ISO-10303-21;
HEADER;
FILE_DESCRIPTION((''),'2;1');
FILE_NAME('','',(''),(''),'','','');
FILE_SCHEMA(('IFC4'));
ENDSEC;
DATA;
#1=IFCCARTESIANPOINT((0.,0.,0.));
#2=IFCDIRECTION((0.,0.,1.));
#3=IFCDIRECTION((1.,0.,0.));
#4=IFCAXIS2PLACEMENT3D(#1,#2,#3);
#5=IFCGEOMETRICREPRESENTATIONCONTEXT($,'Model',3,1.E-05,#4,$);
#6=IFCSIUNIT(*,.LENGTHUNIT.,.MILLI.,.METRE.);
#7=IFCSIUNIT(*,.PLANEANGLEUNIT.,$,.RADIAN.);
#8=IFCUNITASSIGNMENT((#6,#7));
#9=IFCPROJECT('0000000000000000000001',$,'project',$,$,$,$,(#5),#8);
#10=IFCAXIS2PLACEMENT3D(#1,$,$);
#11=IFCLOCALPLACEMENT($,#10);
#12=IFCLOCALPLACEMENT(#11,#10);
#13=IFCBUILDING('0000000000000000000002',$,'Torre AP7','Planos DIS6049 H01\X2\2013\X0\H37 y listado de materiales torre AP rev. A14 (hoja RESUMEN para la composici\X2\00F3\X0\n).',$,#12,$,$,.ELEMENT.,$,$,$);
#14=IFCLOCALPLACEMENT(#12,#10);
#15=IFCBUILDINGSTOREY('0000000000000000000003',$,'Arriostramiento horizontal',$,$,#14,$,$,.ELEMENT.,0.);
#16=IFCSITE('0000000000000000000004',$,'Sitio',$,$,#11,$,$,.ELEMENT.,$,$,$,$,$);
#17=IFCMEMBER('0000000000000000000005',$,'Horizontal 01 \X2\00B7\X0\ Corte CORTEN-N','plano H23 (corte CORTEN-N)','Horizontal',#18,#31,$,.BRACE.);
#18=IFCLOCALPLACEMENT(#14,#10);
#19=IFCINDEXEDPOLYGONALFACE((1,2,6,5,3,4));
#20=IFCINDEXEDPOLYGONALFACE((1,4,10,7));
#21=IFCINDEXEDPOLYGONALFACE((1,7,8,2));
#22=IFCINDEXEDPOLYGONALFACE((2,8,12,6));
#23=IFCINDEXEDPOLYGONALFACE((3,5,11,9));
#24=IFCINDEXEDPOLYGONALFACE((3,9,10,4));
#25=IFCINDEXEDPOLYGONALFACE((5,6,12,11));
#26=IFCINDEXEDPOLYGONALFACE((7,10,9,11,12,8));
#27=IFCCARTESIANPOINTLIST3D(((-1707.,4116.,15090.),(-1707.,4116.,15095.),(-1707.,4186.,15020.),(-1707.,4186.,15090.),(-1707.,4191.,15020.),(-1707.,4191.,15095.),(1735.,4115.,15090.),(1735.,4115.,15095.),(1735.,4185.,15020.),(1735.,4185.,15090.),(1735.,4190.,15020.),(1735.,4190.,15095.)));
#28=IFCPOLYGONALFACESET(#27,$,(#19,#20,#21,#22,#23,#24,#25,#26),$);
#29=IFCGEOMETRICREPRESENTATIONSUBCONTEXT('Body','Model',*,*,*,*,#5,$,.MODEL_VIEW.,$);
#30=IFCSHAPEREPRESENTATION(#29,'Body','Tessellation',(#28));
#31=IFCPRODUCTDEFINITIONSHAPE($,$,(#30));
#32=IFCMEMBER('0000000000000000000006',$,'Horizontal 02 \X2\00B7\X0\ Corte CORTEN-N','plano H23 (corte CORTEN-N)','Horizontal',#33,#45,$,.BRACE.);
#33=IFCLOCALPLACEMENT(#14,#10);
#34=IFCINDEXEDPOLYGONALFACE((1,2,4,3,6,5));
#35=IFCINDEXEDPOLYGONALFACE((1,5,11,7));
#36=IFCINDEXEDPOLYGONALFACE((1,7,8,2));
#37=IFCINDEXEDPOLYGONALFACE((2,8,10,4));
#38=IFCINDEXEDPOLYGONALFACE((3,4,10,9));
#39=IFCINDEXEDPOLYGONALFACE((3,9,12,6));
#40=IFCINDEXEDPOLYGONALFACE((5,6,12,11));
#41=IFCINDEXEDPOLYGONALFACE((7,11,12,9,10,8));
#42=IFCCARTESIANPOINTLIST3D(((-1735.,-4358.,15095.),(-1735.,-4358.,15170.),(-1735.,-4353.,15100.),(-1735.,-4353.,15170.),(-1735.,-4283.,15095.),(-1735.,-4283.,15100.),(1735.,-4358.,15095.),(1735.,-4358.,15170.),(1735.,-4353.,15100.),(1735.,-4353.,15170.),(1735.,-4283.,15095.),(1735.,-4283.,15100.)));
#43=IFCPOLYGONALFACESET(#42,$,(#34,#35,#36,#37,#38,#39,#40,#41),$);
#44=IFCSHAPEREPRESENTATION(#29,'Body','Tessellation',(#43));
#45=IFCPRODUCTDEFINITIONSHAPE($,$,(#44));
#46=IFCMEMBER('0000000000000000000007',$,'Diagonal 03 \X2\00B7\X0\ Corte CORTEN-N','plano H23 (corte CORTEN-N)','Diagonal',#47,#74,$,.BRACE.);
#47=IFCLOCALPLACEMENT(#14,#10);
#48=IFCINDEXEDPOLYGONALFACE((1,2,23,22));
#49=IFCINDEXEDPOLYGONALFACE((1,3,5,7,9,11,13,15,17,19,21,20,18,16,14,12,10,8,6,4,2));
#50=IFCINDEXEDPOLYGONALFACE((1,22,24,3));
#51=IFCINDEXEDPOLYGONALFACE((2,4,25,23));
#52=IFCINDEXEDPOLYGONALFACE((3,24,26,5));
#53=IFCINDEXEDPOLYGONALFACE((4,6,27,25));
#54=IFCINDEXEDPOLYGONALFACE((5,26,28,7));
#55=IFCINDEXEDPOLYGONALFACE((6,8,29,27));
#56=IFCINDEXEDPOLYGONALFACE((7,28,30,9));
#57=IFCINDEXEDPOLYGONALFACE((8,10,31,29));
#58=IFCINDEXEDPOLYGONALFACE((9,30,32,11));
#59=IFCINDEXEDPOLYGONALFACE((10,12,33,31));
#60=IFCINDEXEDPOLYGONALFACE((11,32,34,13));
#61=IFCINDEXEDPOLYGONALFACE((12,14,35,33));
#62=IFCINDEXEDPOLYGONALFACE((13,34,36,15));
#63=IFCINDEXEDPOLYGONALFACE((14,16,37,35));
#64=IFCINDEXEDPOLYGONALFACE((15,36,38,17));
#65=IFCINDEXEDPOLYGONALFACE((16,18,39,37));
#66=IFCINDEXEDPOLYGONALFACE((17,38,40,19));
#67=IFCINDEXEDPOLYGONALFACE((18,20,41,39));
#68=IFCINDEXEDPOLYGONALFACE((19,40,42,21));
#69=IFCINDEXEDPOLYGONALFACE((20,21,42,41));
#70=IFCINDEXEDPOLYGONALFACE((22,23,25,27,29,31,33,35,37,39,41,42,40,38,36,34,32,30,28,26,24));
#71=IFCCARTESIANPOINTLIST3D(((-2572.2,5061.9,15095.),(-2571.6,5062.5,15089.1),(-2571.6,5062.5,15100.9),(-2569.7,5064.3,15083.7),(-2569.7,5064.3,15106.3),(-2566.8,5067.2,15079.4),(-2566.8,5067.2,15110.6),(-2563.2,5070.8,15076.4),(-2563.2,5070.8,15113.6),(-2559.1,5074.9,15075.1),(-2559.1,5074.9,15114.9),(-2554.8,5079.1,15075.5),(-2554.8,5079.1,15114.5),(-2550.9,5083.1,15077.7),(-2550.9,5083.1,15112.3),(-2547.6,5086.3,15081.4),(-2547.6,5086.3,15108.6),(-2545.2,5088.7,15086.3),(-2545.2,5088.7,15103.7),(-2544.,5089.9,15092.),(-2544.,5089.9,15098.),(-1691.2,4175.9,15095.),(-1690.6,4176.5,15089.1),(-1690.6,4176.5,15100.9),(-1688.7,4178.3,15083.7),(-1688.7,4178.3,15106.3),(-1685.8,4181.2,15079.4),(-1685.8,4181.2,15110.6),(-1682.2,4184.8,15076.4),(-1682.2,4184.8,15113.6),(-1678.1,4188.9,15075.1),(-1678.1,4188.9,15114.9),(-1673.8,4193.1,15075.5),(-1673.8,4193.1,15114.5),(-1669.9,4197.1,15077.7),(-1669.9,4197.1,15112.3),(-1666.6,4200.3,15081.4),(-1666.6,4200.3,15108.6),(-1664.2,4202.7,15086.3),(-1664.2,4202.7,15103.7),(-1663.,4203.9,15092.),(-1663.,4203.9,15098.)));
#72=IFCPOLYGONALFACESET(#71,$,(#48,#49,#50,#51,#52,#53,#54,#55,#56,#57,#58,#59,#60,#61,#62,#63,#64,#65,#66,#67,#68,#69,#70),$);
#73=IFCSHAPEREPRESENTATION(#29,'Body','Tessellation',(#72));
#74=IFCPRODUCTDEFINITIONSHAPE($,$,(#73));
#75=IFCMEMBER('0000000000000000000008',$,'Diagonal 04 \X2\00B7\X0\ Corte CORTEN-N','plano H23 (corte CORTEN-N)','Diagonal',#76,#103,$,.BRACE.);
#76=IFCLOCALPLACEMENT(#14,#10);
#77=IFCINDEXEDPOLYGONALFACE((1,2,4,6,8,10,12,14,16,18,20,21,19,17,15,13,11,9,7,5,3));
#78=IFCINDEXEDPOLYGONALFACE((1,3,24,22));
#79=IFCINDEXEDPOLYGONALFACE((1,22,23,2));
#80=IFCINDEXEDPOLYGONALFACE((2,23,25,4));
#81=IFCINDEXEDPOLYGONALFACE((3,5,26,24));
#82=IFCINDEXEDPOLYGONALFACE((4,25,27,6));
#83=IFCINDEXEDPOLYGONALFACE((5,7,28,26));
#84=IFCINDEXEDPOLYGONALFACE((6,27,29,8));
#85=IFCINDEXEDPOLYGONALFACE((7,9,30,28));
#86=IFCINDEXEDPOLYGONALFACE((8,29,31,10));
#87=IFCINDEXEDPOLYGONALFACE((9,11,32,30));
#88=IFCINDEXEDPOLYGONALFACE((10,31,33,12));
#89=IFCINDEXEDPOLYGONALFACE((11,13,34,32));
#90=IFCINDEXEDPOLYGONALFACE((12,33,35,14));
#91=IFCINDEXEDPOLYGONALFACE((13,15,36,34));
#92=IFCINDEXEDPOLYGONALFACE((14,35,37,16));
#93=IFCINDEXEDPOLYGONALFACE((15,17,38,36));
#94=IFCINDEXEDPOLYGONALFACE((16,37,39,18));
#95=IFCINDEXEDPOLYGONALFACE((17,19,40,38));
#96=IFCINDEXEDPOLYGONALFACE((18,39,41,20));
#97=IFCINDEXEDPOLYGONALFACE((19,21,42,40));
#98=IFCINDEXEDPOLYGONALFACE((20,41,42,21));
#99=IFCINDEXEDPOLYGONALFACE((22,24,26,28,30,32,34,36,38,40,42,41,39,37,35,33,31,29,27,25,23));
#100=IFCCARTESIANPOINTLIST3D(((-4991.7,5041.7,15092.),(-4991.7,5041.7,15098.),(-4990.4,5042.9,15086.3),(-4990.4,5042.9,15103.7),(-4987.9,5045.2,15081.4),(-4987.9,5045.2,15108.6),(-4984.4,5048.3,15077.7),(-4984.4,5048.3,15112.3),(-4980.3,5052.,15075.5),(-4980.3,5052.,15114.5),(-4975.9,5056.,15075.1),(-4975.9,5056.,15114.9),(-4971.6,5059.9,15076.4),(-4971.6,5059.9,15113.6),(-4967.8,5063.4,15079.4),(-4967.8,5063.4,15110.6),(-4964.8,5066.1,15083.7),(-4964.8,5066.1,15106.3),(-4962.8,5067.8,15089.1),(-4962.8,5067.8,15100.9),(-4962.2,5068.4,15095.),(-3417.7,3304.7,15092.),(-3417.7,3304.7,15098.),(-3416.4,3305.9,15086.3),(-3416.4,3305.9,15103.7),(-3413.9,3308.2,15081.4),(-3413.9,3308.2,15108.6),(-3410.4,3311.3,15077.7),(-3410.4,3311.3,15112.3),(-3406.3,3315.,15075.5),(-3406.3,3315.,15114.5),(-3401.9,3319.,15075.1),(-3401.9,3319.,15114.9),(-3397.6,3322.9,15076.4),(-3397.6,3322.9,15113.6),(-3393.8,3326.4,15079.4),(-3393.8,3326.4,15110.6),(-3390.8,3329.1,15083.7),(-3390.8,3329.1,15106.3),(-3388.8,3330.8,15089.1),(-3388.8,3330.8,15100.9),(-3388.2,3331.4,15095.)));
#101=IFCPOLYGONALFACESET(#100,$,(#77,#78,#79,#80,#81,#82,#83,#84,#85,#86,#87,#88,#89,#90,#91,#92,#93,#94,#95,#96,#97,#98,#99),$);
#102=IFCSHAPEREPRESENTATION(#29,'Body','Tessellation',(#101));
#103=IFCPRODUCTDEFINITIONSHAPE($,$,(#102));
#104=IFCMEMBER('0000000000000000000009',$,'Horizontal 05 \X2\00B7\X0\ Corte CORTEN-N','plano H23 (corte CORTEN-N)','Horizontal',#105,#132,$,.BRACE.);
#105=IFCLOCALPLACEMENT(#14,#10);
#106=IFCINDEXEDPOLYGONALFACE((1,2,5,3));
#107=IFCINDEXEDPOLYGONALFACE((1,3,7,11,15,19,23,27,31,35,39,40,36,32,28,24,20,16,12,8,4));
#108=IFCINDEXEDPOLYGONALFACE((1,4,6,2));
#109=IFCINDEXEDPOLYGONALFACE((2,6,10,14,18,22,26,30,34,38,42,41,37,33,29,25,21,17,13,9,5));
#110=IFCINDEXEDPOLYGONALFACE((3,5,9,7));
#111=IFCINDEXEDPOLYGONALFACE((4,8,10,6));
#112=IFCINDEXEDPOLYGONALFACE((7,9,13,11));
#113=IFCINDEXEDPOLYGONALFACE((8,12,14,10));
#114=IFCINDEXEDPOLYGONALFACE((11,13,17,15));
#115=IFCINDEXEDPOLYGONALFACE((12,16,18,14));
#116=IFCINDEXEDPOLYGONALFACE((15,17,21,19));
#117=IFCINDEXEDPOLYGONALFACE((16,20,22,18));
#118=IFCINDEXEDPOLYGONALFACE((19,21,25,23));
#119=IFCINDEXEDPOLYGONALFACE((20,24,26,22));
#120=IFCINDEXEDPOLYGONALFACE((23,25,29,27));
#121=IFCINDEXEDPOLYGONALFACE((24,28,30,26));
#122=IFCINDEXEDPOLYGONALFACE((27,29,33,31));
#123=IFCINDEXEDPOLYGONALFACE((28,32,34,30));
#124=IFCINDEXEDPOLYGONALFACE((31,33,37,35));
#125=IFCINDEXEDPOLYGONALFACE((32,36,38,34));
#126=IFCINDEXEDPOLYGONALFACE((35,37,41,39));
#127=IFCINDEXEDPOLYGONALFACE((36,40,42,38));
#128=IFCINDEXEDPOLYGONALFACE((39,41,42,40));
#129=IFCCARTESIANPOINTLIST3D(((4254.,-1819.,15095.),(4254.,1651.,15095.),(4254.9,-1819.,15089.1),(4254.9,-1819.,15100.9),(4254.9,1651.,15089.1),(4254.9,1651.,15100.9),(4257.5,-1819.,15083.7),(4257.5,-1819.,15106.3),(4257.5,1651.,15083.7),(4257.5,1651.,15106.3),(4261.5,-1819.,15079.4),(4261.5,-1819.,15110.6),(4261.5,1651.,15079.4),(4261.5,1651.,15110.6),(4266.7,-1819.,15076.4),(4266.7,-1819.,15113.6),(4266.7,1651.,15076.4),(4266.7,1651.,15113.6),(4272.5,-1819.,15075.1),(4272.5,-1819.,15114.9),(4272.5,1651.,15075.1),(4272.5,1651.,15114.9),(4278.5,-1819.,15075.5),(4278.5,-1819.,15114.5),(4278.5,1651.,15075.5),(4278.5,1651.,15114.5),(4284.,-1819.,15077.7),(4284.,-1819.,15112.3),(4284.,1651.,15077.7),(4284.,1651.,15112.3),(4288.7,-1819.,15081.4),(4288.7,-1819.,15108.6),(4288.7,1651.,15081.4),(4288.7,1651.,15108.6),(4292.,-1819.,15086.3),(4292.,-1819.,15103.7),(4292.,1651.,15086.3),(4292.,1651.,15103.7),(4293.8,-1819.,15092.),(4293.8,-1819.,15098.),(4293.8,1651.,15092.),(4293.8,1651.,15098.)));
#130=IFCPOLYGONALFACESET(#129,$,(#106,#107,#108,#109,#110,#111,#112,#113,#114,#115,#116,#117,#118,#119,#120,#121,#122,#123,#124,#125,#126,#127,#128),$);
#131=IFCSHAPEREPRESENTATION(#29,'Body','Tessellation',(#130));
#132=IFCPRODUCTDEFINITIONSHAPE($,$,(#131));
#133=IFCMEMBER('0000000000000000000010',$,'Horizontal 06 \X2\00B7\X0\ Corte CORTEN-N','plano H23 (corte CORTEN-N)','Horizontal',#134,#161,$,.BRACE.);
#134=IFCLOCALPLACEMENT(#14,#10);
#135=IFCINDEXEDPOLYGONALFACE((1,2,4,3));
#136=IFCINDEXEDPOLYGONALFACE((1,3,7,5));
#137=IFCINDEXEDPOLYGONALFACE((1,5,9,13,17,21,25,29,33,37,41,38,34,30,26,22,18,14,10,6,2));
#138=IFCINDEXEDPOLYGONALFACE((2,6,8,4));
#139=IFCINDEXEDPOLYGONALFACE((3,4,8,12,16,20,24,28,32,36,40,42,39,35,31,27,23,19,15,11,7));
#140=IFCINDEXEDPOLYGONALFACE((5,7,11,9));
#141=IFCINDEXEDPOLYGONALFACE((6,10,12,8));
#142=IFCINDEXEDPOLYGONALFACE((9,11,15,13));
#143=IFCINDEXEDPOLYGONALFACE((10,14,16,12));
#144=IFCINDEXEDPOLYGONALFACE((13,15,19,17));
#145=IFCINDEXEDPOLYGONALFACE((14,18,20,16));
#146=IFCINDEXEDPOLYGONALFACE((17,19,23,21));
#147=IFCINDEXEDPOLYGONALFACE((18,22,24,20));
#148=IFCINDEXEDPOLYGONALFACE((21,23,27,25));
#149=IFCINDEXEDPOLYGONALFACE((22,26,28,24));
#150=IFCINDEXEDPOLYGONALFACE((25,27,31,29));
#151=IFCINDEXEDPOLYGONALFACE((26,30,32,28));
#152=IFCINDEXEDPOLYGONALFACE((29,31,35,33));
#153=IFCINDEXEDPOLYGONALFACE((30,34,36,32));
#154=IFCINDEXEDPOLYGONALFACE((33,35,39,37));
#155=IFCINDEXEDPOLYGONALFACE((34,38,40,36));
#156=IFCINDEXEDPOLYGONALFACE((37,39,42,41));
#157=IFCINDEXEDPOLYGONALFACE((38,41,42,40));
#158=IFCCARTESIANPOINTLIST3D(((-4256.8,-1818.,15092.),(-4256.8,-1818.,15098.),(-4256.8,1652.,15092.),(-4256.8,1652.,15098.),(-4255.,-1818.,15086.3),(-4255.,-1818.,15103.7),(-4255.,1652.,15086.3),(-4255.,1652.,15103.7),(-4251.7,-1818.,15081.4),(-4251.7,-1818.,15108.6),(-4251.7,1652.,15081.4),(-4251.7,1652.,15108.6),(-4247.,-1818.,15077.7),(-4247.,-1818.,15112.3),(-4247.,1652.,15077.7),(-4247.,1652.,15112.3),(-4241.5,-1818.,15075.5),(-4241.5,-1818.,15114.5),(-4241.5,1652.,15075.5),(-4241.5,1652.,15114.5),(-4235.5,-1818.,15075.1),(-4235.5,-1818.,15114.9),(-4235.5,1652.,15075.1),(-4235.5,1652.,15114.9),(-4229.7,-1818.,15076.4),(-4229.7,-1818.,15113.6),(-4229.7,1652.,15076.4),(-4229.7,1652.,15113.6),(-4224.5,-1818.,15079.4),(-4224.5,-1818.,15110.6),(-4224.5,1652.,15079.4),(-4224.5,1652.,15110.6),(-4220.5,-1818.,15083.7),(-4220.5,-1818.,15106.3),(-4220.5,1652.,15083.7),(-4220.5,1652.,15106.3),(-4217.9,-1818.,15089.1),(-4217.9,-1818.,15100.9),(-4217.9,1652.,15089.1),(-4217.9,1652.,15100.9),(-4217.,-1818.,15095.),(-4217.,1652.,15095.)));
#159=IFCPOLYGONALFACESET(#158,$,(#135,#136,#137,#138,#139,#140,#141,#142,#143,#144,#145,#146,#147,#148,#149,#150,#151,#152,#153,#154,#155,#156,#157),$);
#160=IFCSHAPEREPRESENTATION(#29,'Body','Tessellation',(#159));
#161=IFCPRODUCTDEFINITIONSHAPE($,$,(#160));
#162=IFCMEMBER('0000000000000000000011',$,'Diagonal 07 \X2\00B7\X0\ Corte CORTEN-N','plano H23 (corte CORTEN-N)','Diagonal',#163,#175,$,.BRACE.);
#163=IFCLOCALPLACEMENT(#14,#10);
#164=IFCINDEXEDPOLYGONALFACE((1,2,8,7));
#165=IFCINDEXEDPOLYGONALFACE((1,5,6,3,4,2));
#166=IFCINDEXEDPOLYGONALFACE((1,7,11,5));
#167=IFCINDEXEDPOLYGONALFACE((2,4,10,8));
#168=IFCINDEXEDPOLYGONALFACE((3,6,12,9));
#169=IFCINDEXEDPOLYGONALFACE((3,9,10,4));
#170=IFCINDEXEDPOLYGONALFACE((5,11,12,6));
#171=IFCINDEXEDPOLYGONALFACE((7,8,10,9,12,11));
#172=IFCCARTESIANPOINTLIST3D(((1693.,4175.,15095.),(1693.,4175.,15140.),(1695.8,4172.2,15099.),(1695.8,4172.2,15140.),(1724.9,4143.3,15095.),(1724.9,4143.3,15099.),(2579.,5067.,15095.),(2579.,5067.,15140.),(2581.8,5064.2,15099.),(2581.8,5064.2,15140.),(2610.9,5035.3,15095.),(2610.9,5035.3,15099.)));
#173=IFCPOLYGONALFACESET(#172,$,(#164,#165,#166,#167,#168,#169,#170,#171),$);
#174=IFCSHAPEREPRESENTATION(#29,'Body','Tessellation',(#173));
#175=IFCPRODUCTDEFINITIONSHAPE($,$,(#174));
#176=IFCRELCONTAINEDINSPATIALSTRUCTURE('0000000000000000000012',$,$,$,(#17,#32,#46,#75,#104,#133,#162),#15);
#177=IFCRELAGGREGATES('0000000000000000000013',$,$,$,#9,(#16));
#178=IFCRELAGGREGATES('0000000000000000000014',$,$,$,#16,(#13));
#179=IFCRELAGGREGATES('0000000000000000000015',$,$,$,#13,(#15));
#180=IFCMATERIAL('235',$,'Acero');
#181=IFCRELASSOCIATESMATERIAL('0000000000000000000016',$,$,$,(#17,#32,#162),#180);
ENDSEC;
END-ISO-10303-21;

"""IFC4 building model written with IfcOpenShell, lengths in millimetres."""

from ifc_helpers import new_model, si_unit, frame, frame_2d, origin, origin_with_axes, place, context, subcontext, project, spatial, circle, l_section, extrude, material, element, save


model = new_model("IFC4")

# Units and contexts
model_context = context("Model", 3, precision=1e-05, world=origin_with_axes())
body_context = subcontext(model_context, "Body", "Model", "MODEL_VIEW")
ifc_project = project(units=[si_unit("LENGTHUNIT", "METRE", prefix="MILLI"), si_unit("PLANEANGLEUNIT", "RADIAN")], contexts=[model_context])

# Site, building, storey
site_placement = place(None, origin())
site = spatial("IfcSite", under=ifc_project, at=site_placement, Name="Sitio", CompositionType="ELEMENT")
building_placement = place(site_placement, origin())
building = spatial("IfcBuilding", under=site, at=building_placement, Name="Torre AP7", Description="Planos DIS6049 H01–H37 y listado de materiales torre AP rev. A14 (hoja RESUMEN para la composición).", CompositionType="ELEMENT")
storey_placement = place(building_placement, origin())
storey = spatial("IfcBuildingStorey", under=building, at=storey_placement, Name="Arriostramiento horizontal", CompositionType="ELEMENT", Elevation=0.0)

# Members
ifc_material = material(Name="235", Category="Acero")
member_1_placement = place(storey_placement, frame((-1707.0, 4191.0, 15095.0), z_axis=(1.0, -0.000291, 0.0), x_axis=(-0.000291, -1.0, 0.0)))
element("IfcMember", 1, at=member_1_placement, inside=storey, material=ifc_material, Name="Horizontal 01 · Corte CORTEN-N", Description="plano H23 (corte CORTEN-N)", ObjectType="Horizontal", PredefinedType="BRACE", context=body_context, shape_type="SweptSolid", body=[
    extrude(l_section(Depth=75.0, Width=75.0, Thickness=5.0, at=frame_2d((37.5, 37.5))), None, (0.0, 0.0, 1.0), 3442.0),
])
member_2_placement = place(storey_placement, frame((-1735.0, -4358.0, 15095.0), z_axis=(1.0, 0.0, 0.0), x_axis=(0.0, 1.0, 0.0)))
element("IfcMember", 2, at=member_2_placement, inside=storey, material=ifc_material, Name="Horizontal 02 · Corte CORTEN-N", Description="plano H23 (corte CORTEN-N)", ObjectType="Horizontal", PredefinedType="BRACE", context=body_context, shape_type="SweptSolid", body=[
    extrude(l_section(Depth=75.0, Width=75.0, Thickness=5.0, at=frame_2d((37.5, 37.5))), None, (0.0, 0.0, 1.0), 3470.0),
])
member_3_placement = place(storey_placement, frame((-2558.0, 5076.0, 15095.0), z_axis=(0.705103, -0.709105, 0.0), x_axis=(-0.709105, -0.705103, 0.0)))
element("IfcMember", 3, at=member_3_placement, inside=storey, Name="Diagonal 03 · Corte CORTEN-N", Description="plano H23 (corte CORTEN-N)", ObjectType="Diagonal", PredefinedType="BRACE", context=body_context, shape_type="SweptSolid", body=[
    extrude(circle(Radius=20.0), None, (0.0, 0.0, 1.0), 1249.5),
])
member_4_placement = place(storey_placement, frame((-4977.0, 5055.0, 15095.0), z_axis=(0.671483, -0.74102, 0.0), x_axis=(0.74102, 0.671483, 0.0)))
element("IfcMember", 4, at=member_4_placement, inside=storey, Name="Diagonal 04 · Corte CORTEN-N", Description="plano H23 (corte CORTEN-N)", ObjectType="Diagonal", PredefinedType="BRACE", context=body_context, shape_type="SweptSolid", body=[
    extrude(circle(Radius=20.0), None, (0.0, 0.0, 1.0), 2344.1),
])
for number, where, z_axis, x_axis, name in (
    (5, (4274.0, 1651.0, 15095.0), (0.0, -1.0, 0.0), (-1.0, 0.0, 0.0), "Horizontal 05 · Corte CORTEN-N"),
    (6, (-4237.0, 1652.0, 15095.0), (0.0, -1.0, 0.0), (1.0, 0.0, 0.0), "Horizontal 06 · Corte CORTEN-N"),
):
    element("IfcMember", number, at=place(storey_placement, frame(where, z_axis=z_axis, x_axis=x_axis)), inside=storey, Name=name, Description="plano H23 (corte CORTEN-N)", ObjectType="Horizontal", PredefinedType="BRACE", context=body_context, shape_type="SweptSolid", body=[
        extrude(circle(Radius=20.0), None, (0.0, 0.0, 1.0), 3470.0),
    ])
member_5_placement = place(storey_placement, frame((2579.0, 5067.0, 15095.0), z_axis=(-0.704717, -0.709489, 0.0), x_axis=(0.709489, -0.704717, 0.0)))
element("IfcMember", 7, at=member_5_placement, inside=storey, material=ifc_material, Name="Diagonal 07 · Corte CORTEN-N", Description="plano H23 (corte CORTEN-N)", ObjectType="Diagonal", PredefinedType="BRACE", context=body_context, shape_type="SweptSolid", body=[
    extrude(l_section(Depth=45.0, Width=45.0, Thickness=4.0, at=frame_2d((22.5, 22.5))), None, (0.0, 0.0, 1.0), 1257.2),
])

save(model, "model.ifc")
